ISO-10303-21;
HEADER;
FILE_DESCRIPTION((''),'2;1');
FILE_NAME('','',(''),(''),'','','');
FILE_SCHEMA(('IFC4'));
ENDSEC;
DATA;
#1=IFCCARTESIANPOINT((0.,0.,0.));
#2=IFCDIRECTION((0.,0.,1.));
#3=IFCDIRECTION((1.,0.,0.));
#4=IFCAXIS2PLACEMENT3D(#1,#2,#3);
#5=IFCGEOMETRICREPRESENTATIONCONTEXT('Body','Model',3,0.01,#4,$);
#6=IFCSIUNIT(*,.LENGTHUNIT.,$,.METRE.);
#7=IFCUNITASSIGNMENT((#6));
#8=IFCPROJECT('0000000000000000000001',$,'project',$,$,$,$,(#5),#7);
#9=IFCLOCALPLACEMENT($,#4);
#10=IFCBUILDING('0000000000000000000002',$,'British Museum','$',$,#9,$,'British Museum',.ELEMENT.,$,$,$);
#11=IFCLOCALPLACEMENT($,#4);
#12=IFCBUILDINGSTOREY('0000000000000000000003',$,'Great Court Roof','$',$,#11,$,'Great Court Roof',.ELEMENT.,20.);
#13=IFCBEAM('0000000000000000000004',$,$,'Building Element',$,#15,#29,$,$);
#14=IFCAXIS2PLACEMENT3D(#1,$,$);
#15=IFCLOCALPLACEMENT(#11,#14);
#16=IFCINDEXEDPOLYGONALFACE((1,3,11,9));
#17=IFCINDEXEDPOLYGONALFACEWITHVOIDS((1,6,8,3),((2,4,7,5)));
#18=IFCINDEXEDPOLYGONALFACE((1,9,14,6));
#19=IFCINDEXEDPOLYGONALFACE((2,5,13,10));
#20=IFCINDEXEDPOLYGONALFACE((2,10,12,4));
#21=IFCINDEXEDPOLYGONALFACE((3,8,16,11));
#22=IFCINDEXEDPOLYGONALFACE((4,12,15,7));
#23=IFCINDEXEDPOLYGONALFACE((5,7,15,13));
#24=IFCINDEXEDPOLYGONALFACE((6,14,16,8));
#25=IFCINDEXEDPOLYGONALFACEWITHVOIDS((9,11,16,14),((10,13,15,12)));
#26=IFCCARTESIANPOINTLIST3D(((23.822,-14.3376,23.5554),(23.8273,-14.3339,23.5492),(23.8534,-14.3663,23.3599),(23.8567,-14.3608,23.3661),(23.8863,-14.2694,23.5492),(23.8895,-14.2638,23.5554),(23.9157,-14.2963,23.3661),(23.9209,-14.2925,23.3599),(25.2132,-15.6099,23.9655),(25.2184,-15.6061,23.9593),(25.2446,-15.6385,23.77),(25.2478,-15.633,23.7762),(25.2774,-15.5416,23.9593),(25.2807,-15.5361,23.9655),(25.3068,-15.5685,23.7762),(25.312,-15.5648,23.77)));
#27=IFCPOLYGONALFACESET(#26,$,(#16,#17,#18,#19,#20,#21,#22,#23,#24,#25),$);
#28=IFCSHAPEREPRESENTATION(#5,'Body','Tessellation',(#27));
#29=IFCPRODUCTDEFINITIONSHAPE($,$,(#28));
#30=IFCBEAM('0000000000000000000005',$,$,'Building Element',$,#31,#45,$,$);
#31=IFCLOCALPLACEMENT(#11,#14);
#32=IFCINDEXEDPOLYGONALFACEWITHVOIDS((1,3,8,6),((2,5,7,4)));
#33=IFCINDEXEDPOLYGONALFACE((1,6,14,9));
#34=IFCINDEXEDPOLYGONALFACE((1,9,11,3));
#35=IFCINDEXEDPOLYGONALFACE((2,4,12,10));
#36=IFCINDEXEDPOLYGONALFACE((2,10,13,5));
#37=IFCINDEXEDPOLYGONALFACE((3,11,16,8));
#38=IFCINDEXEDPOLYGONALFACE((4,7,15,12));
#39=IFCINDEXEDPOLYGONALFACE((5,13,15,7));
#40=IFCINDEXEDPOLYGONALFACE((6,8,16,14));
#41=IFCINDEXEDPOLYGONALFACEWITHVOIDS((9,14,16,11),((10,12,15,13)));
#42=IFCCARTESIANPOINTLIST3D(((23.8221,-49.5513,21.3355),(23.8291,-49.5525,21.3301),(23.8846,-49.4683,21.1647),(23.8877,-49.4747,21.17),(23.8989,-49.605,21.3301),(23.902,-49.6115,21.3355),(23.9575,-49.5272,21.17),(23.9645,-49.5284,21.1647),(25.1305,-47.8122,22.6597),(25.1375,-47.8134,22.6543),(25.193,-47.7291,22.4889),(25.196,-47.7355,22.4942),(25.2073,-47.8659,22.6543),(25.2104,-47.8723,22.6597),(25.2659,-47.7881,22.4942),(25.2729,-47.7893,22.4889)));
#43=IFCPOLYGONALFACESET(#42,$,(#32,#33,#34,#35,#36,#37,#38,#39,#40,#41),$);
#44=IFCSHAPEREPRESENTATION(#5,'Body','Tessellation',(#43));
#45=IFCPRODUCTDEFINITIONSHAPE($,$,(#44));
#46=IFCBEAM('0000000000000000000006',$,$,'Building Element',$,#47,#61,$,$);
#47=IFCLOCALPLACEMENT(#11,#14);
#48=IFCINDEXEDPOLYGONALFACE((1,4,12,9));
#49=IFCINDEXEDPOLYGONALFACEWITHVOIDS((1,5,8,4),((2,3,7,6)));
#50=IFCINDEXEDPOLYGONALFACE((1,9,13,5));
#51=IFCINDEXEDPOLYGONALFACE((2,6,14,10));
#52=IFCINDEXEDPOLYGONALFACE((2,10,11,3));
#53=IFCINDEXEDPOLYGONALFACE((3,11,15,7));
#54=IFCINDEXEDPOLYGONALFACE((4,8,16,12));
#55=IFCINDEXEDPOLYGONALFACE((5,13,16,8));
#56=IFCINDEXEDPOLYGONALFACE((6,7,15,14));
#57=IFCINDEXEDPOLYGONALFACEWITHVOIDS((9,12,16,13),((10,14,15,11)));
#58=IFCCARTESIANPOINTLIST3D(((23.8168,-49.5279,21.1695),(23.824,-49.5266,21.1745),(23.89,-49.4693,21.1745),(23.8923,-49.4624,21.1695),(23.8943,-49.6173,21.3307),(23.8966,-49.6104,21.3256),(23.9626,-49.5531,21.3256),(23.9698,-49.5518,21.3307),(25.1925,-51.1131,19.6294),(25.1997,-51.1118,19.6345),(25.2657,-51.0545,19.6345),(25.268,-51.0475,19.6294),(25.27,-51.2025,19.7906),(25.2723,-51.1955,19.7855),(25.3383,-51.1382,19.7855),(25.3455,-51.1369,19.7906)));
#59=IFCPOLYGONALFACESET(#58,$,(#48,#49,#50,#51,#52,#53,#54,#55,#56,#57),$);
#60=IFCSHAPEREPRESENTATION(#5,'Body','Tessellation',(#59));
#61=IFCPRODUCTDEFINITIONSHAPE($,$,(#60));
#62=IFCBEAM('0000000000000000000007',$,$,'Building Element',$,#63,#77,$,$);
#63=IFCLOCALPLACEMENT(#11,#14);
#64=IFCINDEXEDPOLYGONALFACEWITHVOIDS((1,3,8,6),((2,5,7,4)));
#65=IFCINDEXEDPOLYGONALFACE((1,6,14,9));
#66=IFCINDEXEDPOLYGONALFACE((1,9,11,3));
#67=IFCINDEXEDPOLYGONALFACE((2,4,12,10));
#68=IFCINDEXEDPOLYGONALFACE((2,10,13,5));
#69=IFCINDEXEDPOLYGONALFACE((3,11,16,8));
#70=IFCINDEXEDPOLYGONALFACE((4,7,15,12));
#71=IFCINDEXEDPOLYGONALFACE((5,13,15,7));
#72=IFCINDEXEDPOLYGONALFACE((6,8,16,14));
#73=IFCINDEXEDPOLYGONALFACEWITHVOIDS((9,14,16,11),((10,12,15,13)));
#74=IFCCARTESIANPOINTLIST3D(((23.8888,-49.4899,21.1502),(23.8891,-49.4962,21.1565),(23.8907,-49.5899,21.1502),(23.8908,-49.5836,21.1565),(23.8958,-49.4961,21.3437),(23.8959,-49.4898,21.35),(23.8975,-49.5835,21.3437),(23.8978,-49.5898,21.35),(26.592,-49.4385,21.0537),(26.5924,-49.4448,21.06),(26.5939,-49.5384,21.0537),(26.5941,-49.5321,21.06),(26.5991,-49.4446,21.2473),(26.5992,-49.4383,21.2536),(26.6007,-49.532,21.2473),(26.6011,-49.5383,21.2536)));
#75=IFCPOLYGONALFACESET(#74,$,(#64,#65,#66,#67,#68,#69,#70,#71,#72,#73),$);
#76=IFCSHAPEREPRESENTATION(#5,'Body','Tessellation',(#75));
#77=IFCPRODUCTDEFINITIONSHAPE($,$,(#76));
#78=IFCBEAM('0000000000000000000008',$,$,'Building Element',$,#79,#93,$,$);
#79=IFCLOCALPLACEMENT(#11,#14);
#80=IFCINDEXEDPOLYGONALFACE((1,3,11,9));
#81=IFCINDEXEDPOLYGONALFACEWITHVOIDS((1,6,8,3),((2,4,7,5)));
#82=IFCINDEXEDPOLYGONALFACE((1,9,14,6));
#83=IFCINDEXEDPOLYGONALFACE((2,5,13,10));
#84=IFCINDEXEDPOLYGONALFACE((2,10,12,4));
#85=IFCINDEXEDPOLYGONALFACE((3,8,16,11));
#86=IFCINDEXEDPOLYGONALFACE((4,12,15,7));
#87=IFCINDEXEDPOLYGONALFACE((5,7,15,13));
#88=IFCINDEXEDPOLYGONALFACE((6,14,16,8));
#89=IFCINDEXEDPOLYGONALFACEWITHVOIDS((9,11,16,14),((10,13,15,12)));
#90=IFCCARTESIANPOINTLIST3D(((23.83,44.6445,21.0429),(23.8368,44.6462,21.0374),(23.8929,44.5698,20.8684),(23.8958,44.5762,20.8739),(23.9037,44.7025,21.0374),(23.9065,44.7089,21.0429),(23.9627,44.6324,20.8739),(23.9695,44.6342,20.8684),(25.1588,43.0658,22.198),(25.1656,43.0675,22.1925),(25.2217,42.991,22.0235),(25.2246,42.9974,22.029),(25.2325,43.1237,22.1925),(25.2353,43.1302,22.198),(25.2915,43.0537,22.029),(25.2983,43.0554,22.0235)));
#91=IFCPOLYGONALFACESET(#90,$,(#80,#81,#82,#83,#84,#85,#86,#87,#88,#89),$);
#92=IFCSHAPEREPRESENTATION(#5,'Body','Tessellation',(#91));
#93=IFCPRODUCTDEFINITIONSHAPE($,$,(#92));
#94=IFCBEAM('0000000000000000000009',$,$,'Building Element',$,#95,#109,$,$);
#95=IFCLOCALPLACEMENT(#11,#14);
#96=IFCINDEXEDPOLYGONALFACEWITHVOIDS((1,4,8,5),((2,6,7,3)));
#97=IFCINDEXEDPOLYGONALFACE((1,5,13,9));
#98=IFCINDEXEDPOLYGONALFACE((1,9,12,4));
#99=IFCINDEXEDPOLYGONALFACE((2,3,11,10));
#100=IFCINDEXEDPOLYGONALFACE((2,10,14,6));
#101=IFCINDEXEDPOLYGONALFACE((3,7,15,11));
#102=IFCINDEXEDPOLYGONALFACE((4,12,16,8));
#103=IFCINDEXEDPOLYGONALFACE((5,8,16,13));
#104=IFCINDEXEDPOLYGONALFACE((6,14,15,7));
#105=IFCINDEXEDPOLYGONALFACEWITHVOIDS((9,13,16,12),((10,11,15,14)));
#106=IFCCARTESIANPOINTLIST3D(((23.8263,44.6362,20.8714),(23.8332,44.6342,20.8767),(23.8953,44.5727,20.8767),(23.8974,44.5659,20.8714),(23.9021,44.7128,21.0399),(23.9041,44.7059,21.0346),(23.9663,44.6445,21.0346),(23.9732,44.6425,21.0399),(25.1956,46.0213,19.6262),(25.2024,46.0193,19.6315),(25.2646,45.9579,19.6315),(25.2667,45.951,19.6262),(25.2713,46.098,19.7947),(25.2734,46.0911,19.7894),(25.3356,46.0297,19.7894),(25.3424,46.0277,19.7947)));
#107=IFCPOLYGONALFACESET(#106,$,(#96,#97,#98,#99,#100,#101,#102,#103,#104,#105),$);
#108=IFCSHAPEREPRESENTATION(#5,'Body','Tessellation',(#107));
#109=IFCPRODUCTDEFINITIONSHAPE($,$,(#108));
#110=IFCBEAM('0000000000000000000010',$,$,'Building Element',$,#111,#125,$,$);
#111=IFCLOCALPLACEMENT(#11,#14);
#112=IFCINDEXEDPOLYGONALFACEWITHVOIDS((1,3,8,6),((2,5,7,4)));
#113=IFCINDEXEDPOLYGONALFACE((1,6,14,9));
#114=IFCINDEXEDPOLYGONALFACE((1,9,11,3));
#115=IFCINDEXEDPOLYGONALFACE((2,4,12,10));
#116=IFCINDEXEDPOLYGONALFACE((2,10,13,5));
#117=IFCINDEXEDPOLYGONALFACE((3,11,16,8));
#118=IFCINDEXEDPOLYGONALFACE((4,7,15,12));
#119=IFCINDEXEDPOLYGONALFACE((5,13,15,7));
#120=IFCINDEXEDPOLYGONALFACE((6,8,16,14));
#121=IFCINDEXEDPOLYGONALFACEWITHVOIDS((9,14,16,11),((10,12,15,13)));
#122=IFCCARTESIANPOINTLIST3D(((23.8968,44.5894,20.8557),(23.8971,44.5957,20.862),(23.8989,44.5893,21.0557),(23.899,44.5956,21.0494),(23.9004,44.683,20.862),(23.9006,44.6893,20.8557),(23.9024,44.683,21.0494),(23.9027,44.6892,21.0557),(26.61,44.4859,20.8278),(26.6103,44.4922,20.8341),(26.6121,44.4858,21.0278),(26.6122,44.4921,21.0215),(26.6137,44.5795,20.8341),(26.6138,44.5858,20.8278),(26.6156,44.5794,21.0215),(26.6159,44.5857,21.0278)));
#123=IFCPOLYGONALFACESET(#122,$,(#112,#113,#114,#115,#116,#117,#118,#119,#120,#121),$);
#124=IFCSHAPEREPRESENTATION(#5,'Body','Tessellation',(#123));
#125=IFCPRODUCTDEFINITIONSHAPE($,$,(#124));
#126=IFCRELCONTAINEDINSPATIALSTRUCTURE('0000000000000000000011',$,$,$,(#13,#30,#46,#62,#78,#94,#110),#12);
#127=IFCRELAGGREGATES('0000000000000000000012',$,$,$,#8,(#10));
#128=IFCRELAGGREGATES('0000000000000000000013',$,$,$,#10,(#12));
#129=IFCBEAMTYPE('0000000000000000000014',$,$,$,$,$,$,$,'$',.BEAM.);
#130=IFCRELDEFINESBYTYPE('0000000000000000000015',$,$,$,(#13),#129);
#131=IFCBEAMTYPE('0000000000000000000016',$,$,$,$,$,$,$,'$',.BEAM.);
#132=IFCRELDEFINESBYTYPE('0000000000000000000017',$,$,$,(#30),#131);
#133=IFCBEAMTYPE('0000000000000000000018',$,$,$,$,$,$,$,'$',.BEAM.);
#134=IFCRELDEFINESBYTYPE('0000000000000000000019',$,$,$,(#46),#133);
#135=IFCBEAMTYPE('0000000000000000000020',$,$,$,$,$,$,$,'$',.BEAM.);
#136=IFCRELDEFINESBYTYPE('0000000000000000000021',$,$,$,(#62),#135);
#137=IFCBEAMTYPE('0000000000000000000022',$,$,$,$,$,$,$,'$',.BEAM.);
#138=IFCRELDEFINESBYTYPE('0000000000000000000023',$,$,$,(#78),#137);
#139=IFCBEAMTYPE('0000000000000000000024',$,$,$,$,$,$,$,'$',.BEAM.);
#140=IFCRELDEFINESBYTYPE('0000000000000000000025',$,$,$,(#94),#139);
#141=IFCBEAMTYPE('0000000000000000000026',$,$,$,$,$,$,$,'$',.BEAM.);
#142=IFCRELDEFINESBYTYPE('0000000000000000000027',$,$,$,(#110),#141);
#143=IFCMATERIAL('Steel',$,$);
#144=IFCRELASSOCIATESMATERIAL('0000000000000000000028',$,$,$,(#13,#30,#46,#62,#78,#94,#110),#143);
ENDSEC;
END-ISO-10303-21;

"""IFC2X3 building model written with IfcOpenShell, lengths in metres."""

from ifc_helpers import new_model, si_unit, frame, origin_with_axes, origin_2d, place, context, project, spatial, hollow_rectangle, extrude, material, type_object, element, save


model = new_model("IFC2X3")

# Units and contexts
model_context = context("Model", 3, precision=0.01, world=origin_with_axes(), identifier="Body")
ifc_project = project(units=[si_unit("LENGTHUNIT", "METRE")], contexts=[model_context])

# Building, storey
building_placement = place(None, origin_with_axes())
building = spatial("IfcBuilding", under=ifc_project, at=building_placement, Name="British Museum", Description="$", LongName="British Museum", CompositionType="ELEMENT")
storey_placement = place(None, origin_with_axes())
storey = spatial("IfcBuildingStorey", under=building, at=storey_placement, Name="Great Court Roof", Description="$", LongName="Great Court Roof", CompositionType="ELEMENT", Elevation=20.0)

# Beams
ifc_material = material(Name="Steel")
beam_type_1 = type_object("IfcBeamType", ElementType="$", PredefinedType="BEAM")
beam_1_placement = place(None, origin_with_axes())
element("IfcBeam", 1, at=beam_1_placement, inside=storey, type_object=beam_type_1, material=ifc_material, Description="Building Element", context=model_context, shape_type="SweptSolid", body=[
    extrude(hollow_rectangle(XDim=0.1, YDim=0.2, WallThickness=0.0063, InnerFilletRadius=-0.0063, OuterFilletRadius=0.0, at=origin_2d()), frame((23.8715, -14.3151, 23.4576), z_axis=(0.721079, -0.659439, 0.21257), x_axis=(0.674862, 0.737944, 0.0)), (0.0, 0.0, 1.0), 1.9293),
])
beam_type_2 = type_object("IfcBeamType", ElementType="$", PredefinedType="BEAM")
beam_2_placement = place(None, origin_with_axes())
element("IfcBeam", 2, at=beam_2_placement, inside=storey, type_object=beam_type_2, material=ifc_material, Description="Building Element", context=model_context, shape_type="SweptSolid", body=[
    extrude(hollow_rectangle(XDim=0.1, YDim=0.2, WallThickness=0.0063, InnerFilletRadius=-0.0063, OuterFilletRadius=0.0, at=origin_2d()), frame((23.8933, -49.5399, 21.2501), z_axis=(0.513586, 0.682673, 0.519796), x_axis=(-0.799111, 0.601184, 0.0)), (0.0, 0.0, 1.0), 2.5475),
])
beam_type_3 = type_object("IfcBeamType", ElementType="$", PredefinedType="BEAM")
beam_3_placement = place(None, origin_with_axes())
element("IfcBeam", 3, at=beam_3_placement, inside=storey, type_object=beam_type_3, material=ifc_material, Description="Building Element", context=model_context, shape_type="SweptSolid", body=[
    extrude(hollow_rectangle(XDim=0.1, YDim=0.2, WallThickness=0.0063, InnerFilletRadius=-0.0063, OuterFilletRadius=0.0, at=origin_2d()), frame((23.8933, -49.5399, 21.2501), z_axis=(0.528448, -0.6089, -0.591594), x_axis=(0.755238, 0.655451, 0.0)), (0.0, 0.0, 1.0), 2.6033),
])
beam_type_4 = type_object("IfcBeamType", ElementType="$", PredefinedType="BEAM")
beam_4_placement = place(None, origin_with_axes())
element("IfcBeam", 4, at=beam_4_placement, inside=storey, type_object=beam_type_4, material=ifc_material, Description="Building Element", context=model_context, shape_type="SweptSolid", body=[
    extrude(hollow_rectangle(XDim=0.1, YDim=0.2, WallThickness=0.0063, InnerFilletRadius=-0.0063, OuterFilletRadius=0.0, at=origin_2d()), frame((23.8933, -49.5399, 21.2501), z_axis=(0.999183, 0.019027, -0.035648), x_axis=(-0.019039, 0.999819, 0.0)), (0.0, 0.0, 1.0), 2.7055),
])
beam_type_5 = type_object("IfcBeamType", ElementType="$", PredefinedType="BEAM")
beam_5_placement = place(None, origin_with_axes())
element("IfcBeam", 5, at=beam_5_placement, inside=storey, type_object=beam_type_5, material=ifc_material, Description="Building Element", context=model_context, shape_type="SweptSolid", body=[
    extrude(hollow_rectangle(XDim=0.1, YDim=0.2, WallThickness=0.0063, InnerFilletRadius=-0.0063, OuterFilletRadius=0.0, at=origin_2d()), frame((23.8997, 44.6393, 20.9557), z_axis=(0.561904, -0.667592, 0.488452), x_axis=(0.765069, 0.643949, 0.0)), (0.0, 0.0, 1.0), 2.3648),
])
beam_type_6 = type_object("IfcBeamType", ElementType="$", PredefinedType="BEAM")
beam_6_placement = place(None, origin_with_axes())
element("IfcBeam", 6, at=beam_6_placement, inside=storey, type_object=beam_type_6, material=ifc_material, Description="Building Element", context=model_context, shape_type="SweptSolid", body=[
    extrude(hollow_rectangle(XDim=0.1, YDim=0.2, WallThickness=0.0063, InnerFilletRadius=-0.0063, OuterFilletRadius=0.0, at=origin_2d()), frame((23.8997, 44.6393, 20.9557), z_axis=(0.592302, 0.599191, -0.538654), x_axis=(-0.711183, 0.703007, 0.0)), (0.0, 0.0, 1.0), 2.3117),
])
beam_type_7 = type_object("IfcBeamType", ElementType="$", PredefinedType="BEAM")
beam_7_placement = place(None, origin_with_axes())
element("IfcBeam", 7, at=beam_7_placement, inside=storey, type_object=beam_type_7, material=ifc_material, Description="Building Element", context=model_context, shape_type="SweptSolid", body=[
    extrude(hollow_rectangle(XDim=0.1, YDim=0.2, WallThickness=0.0063, InnerFilletRadius=-0.0063, OuterFilletRadius=0.0, at=origin_2d()), frame((23.8997, 44.6393, 20.9557), z_axis=(0.99922, -0.038123, -0.010281), x_axis=(0.038125, 0.999273, 0.0)), (0.0, 0.0, 1.0), 2.7153),
])

save(model, "model.ifc")
